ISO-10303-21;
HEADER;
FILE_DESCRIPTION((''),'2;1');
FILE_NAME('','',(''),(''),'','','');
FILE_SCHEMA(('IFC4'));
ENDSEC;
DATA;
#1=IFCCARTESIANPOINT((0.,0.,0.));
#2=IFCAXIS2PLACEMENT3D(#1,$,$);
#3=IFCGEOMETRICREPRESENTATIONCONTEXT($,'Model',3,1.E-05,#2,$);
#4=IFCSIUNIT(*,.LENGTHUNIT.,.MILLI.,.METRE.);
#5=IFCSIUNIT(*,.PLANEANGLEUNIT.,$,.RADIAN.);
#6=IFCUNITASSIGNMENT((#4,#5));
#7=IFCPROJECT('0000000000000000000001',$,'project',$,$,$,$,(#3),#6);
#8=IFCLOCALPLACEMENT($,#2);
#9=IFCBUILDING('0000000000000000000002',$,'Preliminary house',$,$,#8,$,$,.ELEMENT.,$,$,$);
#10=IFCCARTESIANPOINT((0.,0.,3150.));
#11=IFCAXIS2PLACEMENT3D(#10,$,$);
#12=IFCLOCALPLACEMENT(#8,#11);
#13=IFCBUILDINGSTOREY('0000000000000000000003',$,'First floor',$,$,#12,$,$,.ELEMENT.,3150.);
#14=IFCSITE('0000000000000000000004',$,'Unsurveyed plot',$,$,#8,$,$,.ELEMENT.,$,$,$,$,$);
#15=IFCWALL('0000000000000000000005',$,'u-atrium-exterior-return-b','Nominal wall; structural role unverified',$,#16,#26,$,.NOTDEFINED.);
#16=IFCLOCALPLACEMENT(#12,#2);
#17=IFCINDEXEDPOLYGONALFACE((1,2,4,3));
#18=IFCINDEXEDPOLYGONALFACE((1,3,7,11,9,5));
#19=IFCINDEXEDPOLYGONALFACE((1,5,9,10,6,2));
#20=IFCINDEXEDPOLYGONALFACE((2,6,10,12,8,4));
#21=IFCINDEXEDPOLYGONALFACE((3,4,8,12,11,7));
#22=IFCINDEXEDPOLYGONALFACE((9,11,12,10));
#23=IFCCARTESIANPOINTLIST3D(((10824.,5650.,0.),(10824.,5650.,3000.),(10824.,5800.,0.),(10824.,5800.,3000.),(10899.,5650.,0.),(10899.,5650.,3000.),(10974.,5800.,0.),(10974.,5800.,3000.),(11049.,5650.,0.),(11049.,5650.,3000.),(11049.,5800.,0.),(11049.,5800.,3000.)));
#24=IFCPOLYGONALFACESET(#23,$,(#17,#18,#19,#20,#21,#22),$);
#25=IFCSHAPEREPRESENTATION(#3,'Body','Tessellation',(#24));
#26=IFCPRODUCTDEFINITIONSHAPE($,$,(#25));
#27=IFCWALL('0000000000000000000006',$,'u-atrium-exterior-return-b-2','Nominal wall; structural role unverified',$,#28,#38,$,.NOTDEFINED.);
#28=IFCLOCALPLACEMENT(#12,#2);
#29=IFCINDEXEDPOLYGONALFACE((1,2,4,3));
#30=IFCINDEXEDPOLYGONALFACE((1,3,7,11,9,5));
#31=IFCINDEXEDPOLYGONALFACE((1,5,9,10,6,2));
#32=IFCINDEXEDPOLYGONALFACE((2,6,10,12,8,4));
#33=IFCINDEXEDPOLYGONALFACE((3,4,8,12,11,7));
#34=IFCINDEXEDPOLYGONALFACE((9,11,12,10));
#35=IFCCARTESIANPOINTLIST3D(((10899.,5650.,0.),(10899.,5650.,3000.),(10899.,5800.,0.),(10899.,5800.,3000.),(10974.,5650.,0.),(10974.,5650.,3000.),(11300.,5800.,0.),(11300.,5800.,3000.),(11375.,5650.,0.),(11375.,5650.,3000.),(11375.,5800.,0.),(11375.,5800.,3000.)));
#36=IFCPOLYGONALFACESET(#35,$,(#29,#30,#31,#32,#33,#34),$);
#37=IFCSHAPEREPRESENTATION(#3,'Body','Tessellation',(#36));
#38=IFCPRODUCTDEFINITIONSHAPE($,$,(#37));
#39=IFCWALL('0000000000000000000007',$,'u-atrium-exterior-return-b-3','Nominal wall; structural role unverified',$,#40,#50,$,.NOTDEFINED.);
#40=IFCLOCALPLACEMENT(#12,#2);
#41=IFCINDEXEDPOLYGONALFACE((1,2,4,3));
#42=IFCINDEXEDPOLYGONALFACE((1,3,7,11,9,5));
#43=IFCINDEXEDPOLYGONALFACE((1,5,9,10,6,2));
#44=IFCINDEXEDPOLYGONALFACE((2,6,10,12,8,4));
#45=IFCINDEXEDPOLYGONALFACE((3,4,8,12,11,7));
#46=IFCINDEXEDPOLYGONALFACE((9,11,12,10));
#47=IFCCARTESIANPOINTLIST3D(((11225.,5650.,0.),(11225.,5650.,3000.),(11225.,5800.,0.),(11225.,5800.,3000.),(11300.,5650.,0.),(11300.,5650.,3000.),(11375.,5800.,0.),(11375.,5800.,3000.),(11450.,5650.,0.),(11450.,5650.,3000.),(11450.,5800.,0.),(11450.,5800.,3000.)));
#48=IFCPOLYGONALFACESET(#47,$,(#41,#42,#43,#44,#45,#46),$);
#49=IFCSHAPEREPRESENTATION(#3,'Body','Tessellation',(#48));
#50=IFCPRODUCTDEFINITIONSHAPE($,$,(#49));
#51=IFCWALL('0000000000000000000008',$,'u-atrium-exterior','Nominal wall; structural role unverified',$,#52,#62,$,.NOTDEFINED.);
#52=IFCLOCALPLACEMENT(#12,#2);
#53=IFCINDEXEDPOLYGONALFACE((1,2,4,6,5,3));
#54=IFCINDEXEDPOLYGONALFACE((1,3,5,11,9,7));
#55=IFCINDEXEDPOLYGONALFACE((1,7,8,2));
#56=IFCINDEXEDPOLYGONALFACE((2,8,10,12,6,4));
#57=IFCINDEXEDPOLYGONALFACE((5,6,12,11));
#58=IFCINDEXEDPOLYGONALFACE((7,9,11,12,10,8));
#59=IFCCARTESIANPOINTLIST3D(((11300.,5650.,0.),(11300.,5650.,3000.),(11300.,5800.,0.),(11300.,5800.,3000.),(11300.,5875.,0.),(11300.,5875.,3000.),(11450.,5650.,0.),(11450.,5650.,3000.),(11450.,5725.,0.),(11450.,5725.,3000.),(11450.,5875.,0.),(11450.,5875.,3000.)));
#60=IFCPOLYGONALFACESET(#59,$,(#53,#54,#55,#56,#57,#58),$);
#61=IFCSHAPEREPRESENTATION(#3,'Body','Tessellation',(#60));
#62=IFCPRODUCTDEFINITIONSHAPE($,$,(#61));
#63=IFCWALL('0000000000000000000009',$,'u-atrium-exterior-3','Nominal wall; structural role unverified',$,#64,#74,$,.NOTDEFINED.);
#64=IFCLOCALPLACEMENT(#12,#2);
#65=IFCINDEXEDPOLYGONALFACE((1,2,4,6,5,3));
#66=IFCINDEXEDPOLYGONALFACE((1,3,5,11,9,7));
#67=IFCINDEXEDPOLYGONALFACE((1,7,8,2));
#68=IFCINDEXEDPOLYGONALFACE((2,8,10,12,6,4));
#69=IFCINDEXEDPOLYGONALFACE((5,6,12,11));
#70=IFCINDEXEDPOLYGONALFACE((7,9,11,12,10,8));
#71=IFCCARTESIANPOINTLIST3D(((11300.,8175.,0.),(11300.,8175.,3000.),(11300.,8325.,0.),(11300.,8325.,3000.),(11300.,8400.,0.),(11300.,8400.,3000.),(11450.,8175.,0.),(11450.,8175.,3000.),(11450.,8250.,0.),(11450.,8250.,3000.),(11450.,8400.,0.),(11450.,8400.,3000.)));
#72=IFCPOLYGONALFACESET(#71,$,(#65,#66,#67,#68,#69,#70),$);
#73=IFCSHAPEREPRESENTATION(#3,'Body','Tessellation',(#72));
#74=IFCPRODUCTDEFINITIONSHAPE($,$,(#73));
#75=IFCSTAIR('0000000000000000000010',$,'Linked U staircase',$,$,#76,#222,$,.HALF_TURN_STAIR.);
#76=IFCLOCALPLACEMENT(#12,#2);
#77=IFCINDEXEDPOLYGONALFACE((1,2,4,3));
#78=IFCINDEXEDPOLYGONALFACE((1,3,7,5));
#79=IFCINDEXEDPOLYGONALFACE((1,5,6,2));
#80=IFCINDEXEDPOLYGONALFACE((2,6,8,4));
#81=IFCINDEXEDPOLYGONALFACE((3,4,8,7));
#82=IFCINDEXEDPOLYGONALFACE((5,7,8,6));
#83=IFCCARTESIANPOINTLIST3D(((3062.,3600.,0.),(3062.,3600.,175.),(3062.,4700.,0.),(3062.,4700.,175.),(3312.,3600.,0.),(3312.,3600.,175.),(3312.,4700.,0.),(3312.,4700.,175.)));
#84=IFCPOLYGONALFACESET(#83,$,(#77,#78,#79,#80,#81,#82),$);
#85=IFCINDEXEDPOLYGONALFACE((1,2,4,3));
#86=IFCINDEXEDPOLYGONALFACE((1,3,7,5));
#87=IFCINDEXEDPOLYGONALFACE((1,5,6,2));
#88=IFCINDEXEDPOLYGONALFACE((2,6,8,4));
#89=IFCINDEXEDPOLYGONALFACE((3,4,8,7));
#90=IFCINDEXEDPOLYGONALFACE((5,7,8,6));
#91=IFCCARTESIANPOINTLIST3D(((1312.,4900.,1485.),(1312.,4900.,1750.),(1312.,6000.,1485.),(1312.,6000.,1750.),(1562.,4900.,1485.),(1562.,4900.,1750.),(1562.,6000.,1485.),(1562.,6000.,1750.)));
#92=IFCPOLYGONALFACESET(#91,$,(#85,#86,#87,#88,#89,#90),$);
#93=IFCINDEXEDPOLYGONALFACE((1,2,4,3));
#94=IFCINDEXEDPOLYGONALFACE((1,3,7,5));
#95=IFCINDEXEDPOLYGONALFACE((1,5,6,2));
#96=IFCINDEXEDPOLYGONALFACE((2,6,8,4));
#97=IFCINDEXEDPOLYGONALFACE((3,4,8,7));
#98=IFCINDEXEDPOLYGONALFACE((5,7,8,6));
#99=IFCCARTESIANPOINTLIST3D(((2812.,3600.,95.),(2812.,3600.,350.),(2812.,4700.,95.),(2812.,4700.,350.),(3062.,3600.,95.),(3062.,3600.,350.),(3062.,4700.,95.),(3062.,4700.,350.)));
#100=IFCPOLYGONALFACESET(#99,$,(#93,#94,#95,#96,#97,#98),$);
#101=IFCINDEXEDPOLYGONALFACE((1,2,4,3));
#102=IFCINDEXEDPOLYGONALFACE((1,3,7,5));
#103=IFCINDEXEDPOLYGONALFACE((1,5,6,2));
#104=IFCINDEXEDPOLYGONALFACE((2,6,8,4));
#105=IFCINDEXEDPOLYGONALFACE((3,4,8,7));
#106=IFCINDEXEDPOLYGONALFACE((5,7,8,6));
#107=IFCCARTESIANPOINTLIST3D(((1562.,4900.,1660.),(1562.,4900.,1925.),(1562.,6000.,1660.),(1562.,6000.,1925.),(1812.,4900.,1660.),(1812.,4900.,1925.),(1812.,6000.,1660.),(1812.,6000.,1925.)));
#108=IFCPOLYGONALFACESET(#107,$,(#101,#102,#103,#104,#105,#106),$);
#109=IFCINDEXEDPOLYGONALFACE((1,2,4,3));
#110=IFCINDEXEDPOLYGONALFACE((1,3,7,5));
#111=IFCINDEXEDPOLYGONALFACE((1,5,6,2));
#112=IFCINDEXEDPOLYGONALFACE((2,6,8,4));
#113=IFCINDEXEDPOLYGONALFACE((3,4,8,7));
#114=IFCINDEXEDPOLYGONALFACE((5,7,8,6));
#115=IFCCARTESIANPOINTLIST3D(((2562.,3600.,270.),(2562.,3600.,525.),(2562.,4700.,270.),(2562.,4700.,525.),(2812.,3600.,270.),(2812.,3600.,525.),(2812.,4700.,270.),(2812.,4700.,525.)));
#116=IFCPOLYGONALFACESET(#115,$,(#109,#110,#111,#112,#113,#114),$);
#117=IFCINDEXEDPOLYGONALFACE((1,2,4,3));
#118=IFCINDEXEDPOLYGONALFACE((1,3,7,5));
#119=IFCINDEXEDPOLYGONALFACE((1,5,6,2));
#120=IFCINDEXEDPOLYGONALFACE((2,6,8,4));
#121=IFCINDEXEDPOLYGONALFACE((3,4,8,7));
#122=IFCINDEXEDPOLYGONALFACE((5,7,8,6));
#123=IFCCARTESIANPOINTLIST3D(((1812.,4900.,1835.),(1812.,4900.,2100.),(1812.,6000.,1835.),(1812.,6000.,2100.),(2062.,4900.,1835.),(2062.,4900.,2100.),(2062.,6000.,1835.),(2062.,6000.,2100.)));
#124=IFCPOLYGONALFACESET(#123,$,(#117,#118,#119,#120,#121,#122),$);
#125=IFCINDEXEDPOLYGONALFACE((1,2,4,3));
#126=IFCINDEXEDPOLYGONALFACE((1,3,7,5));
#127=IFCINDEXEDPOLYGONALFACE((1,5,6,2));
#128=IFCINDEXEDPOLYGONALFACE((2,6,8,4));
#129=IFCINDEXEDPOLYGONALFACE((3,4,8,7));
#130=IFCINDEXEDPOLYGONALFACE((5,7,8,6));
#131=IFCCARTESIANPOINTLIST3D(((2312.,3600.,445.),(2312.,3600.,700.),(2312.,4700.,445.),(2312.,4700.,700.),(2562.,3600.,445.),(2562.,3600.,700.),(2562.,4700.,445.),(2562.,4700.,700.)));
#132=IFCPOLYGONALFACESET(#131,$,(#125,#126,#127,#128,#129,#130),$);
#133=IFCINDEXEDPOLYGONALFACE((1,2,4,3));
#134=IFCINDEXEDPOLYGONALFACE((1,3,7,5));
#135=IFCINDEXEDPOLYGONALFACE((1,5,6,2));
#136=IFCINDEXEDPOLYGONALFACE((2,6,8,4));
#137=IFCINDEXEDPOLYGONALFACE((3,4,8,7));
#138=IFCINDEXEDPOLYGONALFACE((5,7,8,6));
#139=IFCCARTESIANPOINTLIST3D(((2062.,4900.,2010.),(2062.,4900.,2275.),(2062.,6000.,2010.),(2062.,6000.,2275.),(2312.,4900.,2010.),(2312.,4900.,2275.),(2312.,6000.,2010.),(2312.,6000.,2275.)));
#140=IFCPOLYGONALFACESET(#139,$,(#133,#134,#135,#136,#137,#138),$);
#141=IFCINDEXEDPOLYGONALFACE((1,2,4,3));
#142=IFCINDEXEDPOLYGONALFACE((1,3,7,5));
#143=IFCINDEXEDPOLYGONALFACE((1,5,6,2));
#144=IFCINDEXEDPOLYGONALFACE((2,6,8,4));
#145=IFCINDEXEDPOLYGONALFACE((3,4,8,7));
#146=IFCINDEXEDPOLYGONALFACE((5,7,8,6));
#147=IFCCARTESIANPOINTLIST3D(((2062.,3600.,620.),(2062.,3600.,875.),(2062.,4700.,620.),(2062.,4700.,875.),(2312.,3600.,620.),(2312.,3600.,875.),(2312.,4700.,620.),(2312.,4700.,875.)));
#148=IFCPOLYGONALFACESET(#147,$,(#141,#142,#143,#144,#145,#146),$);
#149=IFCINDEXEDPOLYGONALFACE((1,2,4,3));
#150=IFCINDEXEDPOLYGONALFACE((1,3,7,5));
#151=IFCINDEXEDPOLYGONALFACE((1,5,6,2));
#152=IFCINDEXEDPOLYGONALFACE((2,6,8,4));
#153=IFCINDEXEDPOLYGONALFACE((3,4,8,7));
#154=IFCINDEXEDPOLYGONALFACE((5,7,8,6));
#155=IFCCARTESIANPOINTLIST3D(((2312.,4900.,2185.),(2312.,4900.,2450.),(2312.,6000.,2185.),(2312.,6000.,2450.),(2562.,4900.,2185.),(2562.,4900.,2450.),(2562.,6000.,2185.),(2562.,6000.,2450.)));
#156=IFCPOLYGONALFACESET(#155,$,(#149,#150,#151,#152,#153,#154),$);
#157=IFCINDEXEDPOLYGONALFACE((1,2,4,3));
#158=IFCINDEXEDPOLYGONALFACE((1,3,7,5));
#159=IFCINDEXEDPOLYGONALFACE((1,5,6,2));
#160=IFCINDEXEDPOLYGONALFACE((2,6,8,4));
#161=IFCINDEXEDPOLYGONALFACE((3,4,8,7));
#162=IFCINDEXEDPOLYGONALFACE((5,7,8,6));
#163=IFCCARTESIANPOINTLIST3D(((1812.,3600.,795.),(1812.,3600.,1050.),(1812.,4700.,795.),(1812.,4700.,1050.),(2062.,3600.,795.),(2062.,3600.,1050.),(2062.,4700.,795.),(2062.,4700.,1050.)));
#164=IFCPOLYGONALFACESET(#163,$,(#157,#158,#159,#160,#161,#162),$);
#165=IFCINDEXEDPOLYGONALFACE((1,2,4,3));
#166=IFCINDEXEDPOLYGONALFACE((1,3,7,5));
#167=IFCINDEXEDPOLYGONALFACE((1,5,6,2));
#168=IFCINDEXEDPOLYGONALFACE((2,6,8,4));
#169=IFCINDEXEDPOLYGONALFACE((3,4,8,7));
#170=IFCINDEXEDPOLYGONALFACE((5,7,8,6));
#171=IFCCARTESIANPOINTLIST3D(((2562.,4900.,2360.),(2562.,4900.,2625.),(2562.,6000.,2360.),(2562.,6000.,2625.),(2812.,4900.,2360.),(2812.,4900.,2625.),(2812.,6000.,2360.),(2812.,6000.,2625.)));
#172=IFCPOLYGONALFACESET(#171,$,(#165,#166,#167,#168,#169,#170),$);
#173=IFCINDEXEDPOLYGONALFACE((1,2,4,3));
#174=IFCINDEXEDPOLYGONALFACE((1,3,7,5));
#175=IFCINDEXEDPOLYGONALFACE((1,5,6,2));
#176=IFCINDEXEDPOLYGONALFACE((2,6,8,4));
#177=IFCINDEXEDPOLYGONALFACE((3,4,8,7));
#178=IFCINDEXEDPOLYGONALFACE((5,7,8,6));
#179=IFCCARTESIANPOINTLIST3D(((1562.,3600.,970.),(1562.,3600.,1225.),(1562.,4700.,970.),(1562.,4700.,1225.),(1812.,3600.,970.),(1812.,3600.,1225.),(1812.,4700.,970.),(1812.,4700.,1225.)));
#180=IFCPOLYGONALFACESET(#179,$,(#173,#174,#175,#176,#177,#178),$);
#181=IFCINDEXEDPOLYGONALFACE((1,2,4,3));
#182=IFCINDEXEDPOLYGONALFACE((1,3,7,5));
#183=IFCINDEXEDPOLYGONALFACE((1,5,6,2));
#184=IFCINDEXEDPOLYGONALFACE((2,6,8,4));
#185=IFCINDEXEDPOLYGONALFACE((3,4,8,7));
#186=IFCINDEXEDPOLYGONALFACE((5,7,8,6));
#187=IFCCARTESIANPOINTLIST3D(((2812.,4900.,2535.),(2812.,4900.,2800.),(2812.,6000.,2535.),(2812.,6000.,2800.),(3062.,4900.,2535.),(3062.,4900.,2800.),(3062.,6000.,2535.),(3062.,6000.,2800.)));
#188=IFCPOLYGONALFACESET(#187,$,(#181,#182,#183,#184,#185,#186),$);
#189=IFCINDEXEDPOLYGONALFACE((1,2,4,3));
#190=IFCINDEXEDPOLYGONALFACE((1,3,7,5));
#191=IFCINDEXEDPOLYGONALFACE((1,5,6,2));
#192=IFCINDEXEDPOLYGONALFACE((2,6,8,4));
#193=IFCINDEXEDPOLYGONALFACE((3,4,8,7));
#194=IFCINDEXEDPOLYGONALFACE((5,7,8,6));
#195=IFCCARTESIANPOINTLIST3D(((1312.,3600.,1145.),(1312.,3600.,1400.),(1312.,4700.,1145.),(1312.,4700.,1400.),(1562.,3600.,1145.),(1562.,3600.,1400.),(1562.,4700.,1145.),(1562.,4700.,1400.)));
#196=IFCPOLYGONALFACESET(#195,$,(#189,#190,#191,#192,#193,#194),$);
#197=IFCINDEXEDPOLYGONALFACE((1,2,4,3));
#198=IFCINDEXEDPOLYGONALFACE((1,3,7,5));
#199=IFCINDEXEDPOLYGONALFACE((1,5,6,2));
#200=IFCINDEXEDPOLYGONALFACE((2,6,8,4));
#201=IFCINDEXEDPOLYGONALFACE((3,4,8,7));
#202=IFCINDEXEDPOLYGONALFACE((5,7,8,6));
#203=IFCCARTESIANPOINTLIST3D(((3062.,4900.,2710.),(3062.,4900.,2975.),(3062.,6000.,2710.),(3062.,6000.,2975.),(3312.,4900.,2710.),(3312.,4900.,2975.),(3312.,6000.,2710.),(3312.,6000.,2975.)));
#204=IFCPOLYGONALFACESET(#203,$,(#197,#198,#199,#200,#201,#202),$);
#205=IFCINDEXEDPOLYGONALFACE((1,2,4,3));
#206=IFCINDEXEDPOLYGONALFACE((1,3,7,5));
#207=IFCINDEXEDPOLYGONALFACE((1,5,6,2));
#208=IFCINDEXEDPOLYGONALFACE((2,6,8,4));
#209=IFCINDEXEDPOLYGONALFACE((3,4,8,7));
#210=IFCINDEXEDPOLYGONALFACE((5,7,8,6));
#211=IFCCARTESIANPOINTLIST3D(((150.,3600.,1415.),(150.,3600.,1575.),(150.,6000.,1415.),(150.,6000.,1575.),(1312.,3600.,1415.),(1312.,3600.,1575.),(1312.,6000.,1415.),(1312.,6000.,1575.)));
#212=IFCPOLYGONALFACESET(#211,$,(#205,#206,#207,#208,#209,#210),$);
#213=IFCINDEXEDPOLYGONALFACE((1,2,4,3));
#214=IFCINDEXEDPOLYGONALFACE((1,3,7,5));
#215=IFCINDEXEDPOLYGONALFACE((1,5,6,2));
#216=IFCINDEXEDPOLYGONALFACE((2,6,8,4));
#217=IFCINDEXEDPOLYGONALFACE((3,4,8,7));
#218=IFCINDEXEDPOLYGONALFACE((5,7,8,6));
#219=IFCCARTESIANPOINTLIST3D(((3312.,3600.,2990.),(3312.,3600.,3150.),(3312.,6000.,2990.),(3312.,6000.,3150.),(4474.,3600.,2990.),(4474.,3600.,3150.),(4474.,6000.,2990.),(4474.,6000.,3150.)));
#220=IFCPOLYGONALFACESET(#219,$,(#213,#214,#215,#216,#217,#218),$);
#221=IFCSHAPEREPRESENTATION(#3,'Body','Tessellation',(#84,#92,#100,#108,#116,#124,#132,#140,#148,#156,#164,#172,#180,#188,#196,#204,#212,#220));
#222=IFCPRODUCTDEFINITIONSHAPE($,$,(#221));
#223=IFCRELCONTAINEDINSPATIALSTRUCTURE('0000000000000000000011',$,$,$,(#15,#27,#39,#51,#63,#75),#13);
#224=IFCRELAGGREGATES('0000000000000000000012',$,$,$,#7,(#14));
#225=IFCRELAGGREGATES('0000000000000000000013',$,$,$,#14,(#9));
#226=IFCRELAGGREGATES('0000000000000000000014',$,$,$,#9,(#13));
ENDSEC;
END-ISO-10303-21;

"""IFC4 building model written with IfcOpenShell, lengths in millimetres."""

from ifc_helpers import new_model, si_unit, frame, origin, place, context, project, spatial, polyline, outline, extrude, element, save


model = new_model("IFC4")

# Units and contexts
model_context = context("Model", 3, precision=1e-05, world=origin())
ifc_project = project(units=[si_unit("LENGTHUNIT", "METRE", prefix="MILLI"), si_unit("PLANEANGLEUNIT", "RADIAN")], contexts=[model_context])

# Site, building, storey
placement_1 = place(None, origin())
site = spatial("IfcSite", under=ifc_project, at=placement_1, Name="Unsurveyed plot", CompositionType="ELEMENT")
building = spatial("IfcBuilding", under=site, at=placement_1, Name="Preliminary house", CompositionType="ELEMENT")
placement_2 = place(placement_1, frame((0.0, 0.0, 3150.0)))
storey = spatial("IfcBuildingStorey", under=building, at=placement_2, Name="First floor", CompositionType="ELEMENT", Elevation=3150.0)

# Walls
element("IfcWall", 1, at=placement_2, inside=storey, Name="u-atrium-exterior-return-b", Description="Nominal wall; structural role unverified", PredefinedType="NOTDEFINED", context=model_context, shape_type="SweptSolid", body=[
    extrude(outline(polyline([(10974.0, 5800.0), (11049.0, 5800.0), (11049.0, 5650.0), (10899.0, 5650.0), (10824.0, 5650.0), (10824.0, 5800.0), (10974.0, 5800.0)])), origin(), (0.0, 0.0, 1.0), 3000.0),
])
element("IfcWall", 2, at=placement_2, inside=storey, Name="u-atrium-exterior-return-b-2", Description="Nominal wall; structural role unverified", PredefinedType="NOTDEFINED", context=model_context, shape_type="SweptSolid", body=[
    extrude(outline(polyline([(11300.0, 5800.0), (11375.0, 5800.0), (11375.0, 5650.0), (10974.0, 5650.0), (10899.0, 5650.0), (10899.0, 5800.0), (11300.0, 5800.0)])), origin(), (0.0, 0.0, 1.0), 3000.0),
])
element("IfcWall", 3, at=placement_2, inside=storey, Name="u-atrium-exterior-return-b-3", Description="Nominal wall; structural role unverified", PredefinedType="NOTDEFINED", context=model_context, shape_type="SweptSolid", body=[
    extrude(outline(polyline([(11375.0, 5800.0), (11450.0, 5800.0), (11450.0, 5650.0), (11300.0, 5650.0), (11225.0, 5650.0), (11225.0, 5800.0), (11375.0, 5800.0)])), origin(), (0.0, 0.0, 1.0), 3000.0),
])
element("IfcWall", 4, at=placement_2, inside=storey, Name="u-atrium-exterior", Description="Nominal wall; structural role unverified", PredefinedType="NOTDEFINED", context=model_context, shape_type="SweptSolid", body=[
    extrude(outline(polyline([(11300.0, 5800.0), (11300.0, 5875.0), (11450.0, 5875.0), (11450.0, 5725.0), (11450.0, 5650.0), (11300.0, 5650.0), (11300.0, 5800.0)])), origin(), (0.0, 0.0, 1.0), 3000.0),
])

# Wall
element("IfcWall", 5, at=placement_2, inside=storey, Name="u-atrium-exterior-3", Description="Nominal wall; structural role unverified", PredefinedType="NOTDEFINED", context=model_context, shape_type="SweptSolid", body=[
    extrude(outline(polyline([(11300.0, 8325.0), (11300.0, 8400.0), (11450.0, 8400.0), (11450.0, 8250.0), (11450.0, 8175.0), (11300.0, 8175.0), (11300.0, 8325.0)])), origin(), (0.0, 0.0, 1.0), 3000.0),
])

# Stair
element("IfcStair", 6, at=placement_2, inside=storey, Name="Linked U staircase", PredefinedType="HALF_TURN_STAIR", context=model_context, shape_type="SweptSolid", body=[
    extrude(outline(polyline([(3312.0, 4700.0), (3062.0, 4700.0), (3062.0, 3600.0), (3312.0, 3600.0), (3312.0, 4700.0)])), origin(), (0.0, 0.0, 1.0), 175.0),
    extrude(outline(polyline([(1562.0, 6000.0), (1312.0, 6000.0), (1312.0, 4900.0), (1562.0, 4900.0), (1562.0, 6000.0)])), frame((0.0, 0.0, 1485.0)), (0.0, 0.0, 1.0), 265.0),
    extrude(outline(polyline([(3062.0, 4700.0), (2812.0, 4700.0), (2812.0, 3600.0), (3062.0, 3600.0), (3062.0, 4700.0)])), frame((0.0, 0.0, 95.0)), (0.0, 0.0, 1.0), 255.0),
    extrude(outline(polyline([(1812.0, 6000.0), (1562.0, 6000.0), (1562.0, 4900.0), (1812.0, 4900.0), (1812.0, 6000.0)])), frame((0.0, 0.0, 1660.0)), (0.0, 0.0, 1.0), 265.0),
    extrude(outline(polyline([(2812.0, 4700.0), (2562.0, 4700.0), (2562.0, 3600.0), (2812.0, 3600.0), (2812.0, 4700.0)])), frame((0.0, 0.0, 270.0)), (0.0, 0.0, 1.0), 255.0),
    extrude(outline(polyline([(2062.0, 6000.0), (1812.0, 6000.0), (1812.0, 4900.0), (2062.0, 4900.0), (2062.0, 6000.0)])), frame((0.0, 0.0, 1835.0)), (0.0, 0.0, 1.0), 265.0),
    extrude(outline(polyline([(2562.0, 4700.0), (2312.0, 4700.0), (2312.0, 3600.0), (2562.0, 3600.0), (2562.0, 4700.0)])), frame((0.0, 0.0, 445.0)), (0.0, 0.0, 1.0), 255.0),
    extrude(outline(polyline([(2312.0, 6000.0), (2062.0, 6000.0), (2062.0, 4900.0), (2312.0, 4900.0), (2312.0, 6000.0)])), frame((0.0, 0.0, 2010.0)), (0.0, 0.0, 1.0), 265.0),
    extrude(outline(polyline([(2312.0, 4700.0), (2062.0, 4700.0), (2062.0, 3600.0), (2312.0, 3600.0), (2312.0, 4700.0)])), frame((0.0, 0.0, 620.0)), (0.0, 0.0, 1.0), 255.0),
    extrude(outline(polyline([(2562.0, 6000.0), (2312.0, 6000.0), (2312.0, 4900.0), (2562.0, 4900.0), (2562.0, 6000.0)])), frame((0.0, 0.0, 2185.0)), (0.0, 0.0, 1.0), 265.0),
    extrude(outline(polyline([(2062.0, 4700.0), (1812.0, 4700.0), (1812.0, 3600.0), (2062.0, 3600.0), (2062.0, 4700.0)])), frame((0.0, 0.0, 795.0)), (0.0, 0.0, 1.0), 255.0),
    extrude(outline(polyline([(2812.0, 6000.0), (2562.0, 6000.0), (2562.0, 4900.0), (2812.0, 4900.0), (2812.0, 6000.0)])), frame((0.0, 0.0, 2360.0)), (0.0, 0.0, 1.0), 265.0),
    extrude(outline(polyline([(1812.0, 4700.0), (1562.0, 4700.0), (1562.0, 3600.0), (1812.0, 3600.0), (1812.0, 4700.0)])), frame((0.0, 0.0, 970.0)), (0.0, 0.0, 1.0), 255.0),
    extrude(outline(polyline([(3062.0, 6000.0), (2812.0, 6000.0), (2812.0, 4900.0), (3062.0, 4900.0), (3062.0, 6000.0)])), frame((0.0, 0.0, 2535.0)), (0.0, 0.0, 1.0), 265.0),
    extrude(outline(polyline([(1562.0, 4700.0), (1312.0, 4700.0), (1312.0, 3600.0), (1562.0, 3600.0), (1562.0, 4700.0)])), frame((0.0, 0.0, 1145.0)), (0.0, 0.0, 1.0), 255.0),
    extrude(outline(polyline([(3312.0, 6000.0), (3062.0, 6000.0), (3062.0, 4900.0), (3312.0, 4900.0), (3312.0, 6000.0)])), frame((0.0, 0.0, 2710.0)), (0.0, 0.0, 1.0), 265.0),
    extrude(outline(polyline([(1312.0, 6000.0), (150.0, 6000.0), (150.0, 3600.0), (1312.0, 3600.0), (1312.0, 6000.0)])), frame((0.0, 0.0, 1415.0)), (0.0, 0.0, 1.0), 160.0),
    extrude(outline(polyline([(4474.0, 6000.0), (3312.0, 6000.0), (3312.0, 3600.0), (4474.0, 3600.0), (4474.0, 6000.0)])), frame((0.0, 0.0, 2990.0)), (0.0, 0.0, 1.0), 160.0),
])

save(model, "model.ifc")
